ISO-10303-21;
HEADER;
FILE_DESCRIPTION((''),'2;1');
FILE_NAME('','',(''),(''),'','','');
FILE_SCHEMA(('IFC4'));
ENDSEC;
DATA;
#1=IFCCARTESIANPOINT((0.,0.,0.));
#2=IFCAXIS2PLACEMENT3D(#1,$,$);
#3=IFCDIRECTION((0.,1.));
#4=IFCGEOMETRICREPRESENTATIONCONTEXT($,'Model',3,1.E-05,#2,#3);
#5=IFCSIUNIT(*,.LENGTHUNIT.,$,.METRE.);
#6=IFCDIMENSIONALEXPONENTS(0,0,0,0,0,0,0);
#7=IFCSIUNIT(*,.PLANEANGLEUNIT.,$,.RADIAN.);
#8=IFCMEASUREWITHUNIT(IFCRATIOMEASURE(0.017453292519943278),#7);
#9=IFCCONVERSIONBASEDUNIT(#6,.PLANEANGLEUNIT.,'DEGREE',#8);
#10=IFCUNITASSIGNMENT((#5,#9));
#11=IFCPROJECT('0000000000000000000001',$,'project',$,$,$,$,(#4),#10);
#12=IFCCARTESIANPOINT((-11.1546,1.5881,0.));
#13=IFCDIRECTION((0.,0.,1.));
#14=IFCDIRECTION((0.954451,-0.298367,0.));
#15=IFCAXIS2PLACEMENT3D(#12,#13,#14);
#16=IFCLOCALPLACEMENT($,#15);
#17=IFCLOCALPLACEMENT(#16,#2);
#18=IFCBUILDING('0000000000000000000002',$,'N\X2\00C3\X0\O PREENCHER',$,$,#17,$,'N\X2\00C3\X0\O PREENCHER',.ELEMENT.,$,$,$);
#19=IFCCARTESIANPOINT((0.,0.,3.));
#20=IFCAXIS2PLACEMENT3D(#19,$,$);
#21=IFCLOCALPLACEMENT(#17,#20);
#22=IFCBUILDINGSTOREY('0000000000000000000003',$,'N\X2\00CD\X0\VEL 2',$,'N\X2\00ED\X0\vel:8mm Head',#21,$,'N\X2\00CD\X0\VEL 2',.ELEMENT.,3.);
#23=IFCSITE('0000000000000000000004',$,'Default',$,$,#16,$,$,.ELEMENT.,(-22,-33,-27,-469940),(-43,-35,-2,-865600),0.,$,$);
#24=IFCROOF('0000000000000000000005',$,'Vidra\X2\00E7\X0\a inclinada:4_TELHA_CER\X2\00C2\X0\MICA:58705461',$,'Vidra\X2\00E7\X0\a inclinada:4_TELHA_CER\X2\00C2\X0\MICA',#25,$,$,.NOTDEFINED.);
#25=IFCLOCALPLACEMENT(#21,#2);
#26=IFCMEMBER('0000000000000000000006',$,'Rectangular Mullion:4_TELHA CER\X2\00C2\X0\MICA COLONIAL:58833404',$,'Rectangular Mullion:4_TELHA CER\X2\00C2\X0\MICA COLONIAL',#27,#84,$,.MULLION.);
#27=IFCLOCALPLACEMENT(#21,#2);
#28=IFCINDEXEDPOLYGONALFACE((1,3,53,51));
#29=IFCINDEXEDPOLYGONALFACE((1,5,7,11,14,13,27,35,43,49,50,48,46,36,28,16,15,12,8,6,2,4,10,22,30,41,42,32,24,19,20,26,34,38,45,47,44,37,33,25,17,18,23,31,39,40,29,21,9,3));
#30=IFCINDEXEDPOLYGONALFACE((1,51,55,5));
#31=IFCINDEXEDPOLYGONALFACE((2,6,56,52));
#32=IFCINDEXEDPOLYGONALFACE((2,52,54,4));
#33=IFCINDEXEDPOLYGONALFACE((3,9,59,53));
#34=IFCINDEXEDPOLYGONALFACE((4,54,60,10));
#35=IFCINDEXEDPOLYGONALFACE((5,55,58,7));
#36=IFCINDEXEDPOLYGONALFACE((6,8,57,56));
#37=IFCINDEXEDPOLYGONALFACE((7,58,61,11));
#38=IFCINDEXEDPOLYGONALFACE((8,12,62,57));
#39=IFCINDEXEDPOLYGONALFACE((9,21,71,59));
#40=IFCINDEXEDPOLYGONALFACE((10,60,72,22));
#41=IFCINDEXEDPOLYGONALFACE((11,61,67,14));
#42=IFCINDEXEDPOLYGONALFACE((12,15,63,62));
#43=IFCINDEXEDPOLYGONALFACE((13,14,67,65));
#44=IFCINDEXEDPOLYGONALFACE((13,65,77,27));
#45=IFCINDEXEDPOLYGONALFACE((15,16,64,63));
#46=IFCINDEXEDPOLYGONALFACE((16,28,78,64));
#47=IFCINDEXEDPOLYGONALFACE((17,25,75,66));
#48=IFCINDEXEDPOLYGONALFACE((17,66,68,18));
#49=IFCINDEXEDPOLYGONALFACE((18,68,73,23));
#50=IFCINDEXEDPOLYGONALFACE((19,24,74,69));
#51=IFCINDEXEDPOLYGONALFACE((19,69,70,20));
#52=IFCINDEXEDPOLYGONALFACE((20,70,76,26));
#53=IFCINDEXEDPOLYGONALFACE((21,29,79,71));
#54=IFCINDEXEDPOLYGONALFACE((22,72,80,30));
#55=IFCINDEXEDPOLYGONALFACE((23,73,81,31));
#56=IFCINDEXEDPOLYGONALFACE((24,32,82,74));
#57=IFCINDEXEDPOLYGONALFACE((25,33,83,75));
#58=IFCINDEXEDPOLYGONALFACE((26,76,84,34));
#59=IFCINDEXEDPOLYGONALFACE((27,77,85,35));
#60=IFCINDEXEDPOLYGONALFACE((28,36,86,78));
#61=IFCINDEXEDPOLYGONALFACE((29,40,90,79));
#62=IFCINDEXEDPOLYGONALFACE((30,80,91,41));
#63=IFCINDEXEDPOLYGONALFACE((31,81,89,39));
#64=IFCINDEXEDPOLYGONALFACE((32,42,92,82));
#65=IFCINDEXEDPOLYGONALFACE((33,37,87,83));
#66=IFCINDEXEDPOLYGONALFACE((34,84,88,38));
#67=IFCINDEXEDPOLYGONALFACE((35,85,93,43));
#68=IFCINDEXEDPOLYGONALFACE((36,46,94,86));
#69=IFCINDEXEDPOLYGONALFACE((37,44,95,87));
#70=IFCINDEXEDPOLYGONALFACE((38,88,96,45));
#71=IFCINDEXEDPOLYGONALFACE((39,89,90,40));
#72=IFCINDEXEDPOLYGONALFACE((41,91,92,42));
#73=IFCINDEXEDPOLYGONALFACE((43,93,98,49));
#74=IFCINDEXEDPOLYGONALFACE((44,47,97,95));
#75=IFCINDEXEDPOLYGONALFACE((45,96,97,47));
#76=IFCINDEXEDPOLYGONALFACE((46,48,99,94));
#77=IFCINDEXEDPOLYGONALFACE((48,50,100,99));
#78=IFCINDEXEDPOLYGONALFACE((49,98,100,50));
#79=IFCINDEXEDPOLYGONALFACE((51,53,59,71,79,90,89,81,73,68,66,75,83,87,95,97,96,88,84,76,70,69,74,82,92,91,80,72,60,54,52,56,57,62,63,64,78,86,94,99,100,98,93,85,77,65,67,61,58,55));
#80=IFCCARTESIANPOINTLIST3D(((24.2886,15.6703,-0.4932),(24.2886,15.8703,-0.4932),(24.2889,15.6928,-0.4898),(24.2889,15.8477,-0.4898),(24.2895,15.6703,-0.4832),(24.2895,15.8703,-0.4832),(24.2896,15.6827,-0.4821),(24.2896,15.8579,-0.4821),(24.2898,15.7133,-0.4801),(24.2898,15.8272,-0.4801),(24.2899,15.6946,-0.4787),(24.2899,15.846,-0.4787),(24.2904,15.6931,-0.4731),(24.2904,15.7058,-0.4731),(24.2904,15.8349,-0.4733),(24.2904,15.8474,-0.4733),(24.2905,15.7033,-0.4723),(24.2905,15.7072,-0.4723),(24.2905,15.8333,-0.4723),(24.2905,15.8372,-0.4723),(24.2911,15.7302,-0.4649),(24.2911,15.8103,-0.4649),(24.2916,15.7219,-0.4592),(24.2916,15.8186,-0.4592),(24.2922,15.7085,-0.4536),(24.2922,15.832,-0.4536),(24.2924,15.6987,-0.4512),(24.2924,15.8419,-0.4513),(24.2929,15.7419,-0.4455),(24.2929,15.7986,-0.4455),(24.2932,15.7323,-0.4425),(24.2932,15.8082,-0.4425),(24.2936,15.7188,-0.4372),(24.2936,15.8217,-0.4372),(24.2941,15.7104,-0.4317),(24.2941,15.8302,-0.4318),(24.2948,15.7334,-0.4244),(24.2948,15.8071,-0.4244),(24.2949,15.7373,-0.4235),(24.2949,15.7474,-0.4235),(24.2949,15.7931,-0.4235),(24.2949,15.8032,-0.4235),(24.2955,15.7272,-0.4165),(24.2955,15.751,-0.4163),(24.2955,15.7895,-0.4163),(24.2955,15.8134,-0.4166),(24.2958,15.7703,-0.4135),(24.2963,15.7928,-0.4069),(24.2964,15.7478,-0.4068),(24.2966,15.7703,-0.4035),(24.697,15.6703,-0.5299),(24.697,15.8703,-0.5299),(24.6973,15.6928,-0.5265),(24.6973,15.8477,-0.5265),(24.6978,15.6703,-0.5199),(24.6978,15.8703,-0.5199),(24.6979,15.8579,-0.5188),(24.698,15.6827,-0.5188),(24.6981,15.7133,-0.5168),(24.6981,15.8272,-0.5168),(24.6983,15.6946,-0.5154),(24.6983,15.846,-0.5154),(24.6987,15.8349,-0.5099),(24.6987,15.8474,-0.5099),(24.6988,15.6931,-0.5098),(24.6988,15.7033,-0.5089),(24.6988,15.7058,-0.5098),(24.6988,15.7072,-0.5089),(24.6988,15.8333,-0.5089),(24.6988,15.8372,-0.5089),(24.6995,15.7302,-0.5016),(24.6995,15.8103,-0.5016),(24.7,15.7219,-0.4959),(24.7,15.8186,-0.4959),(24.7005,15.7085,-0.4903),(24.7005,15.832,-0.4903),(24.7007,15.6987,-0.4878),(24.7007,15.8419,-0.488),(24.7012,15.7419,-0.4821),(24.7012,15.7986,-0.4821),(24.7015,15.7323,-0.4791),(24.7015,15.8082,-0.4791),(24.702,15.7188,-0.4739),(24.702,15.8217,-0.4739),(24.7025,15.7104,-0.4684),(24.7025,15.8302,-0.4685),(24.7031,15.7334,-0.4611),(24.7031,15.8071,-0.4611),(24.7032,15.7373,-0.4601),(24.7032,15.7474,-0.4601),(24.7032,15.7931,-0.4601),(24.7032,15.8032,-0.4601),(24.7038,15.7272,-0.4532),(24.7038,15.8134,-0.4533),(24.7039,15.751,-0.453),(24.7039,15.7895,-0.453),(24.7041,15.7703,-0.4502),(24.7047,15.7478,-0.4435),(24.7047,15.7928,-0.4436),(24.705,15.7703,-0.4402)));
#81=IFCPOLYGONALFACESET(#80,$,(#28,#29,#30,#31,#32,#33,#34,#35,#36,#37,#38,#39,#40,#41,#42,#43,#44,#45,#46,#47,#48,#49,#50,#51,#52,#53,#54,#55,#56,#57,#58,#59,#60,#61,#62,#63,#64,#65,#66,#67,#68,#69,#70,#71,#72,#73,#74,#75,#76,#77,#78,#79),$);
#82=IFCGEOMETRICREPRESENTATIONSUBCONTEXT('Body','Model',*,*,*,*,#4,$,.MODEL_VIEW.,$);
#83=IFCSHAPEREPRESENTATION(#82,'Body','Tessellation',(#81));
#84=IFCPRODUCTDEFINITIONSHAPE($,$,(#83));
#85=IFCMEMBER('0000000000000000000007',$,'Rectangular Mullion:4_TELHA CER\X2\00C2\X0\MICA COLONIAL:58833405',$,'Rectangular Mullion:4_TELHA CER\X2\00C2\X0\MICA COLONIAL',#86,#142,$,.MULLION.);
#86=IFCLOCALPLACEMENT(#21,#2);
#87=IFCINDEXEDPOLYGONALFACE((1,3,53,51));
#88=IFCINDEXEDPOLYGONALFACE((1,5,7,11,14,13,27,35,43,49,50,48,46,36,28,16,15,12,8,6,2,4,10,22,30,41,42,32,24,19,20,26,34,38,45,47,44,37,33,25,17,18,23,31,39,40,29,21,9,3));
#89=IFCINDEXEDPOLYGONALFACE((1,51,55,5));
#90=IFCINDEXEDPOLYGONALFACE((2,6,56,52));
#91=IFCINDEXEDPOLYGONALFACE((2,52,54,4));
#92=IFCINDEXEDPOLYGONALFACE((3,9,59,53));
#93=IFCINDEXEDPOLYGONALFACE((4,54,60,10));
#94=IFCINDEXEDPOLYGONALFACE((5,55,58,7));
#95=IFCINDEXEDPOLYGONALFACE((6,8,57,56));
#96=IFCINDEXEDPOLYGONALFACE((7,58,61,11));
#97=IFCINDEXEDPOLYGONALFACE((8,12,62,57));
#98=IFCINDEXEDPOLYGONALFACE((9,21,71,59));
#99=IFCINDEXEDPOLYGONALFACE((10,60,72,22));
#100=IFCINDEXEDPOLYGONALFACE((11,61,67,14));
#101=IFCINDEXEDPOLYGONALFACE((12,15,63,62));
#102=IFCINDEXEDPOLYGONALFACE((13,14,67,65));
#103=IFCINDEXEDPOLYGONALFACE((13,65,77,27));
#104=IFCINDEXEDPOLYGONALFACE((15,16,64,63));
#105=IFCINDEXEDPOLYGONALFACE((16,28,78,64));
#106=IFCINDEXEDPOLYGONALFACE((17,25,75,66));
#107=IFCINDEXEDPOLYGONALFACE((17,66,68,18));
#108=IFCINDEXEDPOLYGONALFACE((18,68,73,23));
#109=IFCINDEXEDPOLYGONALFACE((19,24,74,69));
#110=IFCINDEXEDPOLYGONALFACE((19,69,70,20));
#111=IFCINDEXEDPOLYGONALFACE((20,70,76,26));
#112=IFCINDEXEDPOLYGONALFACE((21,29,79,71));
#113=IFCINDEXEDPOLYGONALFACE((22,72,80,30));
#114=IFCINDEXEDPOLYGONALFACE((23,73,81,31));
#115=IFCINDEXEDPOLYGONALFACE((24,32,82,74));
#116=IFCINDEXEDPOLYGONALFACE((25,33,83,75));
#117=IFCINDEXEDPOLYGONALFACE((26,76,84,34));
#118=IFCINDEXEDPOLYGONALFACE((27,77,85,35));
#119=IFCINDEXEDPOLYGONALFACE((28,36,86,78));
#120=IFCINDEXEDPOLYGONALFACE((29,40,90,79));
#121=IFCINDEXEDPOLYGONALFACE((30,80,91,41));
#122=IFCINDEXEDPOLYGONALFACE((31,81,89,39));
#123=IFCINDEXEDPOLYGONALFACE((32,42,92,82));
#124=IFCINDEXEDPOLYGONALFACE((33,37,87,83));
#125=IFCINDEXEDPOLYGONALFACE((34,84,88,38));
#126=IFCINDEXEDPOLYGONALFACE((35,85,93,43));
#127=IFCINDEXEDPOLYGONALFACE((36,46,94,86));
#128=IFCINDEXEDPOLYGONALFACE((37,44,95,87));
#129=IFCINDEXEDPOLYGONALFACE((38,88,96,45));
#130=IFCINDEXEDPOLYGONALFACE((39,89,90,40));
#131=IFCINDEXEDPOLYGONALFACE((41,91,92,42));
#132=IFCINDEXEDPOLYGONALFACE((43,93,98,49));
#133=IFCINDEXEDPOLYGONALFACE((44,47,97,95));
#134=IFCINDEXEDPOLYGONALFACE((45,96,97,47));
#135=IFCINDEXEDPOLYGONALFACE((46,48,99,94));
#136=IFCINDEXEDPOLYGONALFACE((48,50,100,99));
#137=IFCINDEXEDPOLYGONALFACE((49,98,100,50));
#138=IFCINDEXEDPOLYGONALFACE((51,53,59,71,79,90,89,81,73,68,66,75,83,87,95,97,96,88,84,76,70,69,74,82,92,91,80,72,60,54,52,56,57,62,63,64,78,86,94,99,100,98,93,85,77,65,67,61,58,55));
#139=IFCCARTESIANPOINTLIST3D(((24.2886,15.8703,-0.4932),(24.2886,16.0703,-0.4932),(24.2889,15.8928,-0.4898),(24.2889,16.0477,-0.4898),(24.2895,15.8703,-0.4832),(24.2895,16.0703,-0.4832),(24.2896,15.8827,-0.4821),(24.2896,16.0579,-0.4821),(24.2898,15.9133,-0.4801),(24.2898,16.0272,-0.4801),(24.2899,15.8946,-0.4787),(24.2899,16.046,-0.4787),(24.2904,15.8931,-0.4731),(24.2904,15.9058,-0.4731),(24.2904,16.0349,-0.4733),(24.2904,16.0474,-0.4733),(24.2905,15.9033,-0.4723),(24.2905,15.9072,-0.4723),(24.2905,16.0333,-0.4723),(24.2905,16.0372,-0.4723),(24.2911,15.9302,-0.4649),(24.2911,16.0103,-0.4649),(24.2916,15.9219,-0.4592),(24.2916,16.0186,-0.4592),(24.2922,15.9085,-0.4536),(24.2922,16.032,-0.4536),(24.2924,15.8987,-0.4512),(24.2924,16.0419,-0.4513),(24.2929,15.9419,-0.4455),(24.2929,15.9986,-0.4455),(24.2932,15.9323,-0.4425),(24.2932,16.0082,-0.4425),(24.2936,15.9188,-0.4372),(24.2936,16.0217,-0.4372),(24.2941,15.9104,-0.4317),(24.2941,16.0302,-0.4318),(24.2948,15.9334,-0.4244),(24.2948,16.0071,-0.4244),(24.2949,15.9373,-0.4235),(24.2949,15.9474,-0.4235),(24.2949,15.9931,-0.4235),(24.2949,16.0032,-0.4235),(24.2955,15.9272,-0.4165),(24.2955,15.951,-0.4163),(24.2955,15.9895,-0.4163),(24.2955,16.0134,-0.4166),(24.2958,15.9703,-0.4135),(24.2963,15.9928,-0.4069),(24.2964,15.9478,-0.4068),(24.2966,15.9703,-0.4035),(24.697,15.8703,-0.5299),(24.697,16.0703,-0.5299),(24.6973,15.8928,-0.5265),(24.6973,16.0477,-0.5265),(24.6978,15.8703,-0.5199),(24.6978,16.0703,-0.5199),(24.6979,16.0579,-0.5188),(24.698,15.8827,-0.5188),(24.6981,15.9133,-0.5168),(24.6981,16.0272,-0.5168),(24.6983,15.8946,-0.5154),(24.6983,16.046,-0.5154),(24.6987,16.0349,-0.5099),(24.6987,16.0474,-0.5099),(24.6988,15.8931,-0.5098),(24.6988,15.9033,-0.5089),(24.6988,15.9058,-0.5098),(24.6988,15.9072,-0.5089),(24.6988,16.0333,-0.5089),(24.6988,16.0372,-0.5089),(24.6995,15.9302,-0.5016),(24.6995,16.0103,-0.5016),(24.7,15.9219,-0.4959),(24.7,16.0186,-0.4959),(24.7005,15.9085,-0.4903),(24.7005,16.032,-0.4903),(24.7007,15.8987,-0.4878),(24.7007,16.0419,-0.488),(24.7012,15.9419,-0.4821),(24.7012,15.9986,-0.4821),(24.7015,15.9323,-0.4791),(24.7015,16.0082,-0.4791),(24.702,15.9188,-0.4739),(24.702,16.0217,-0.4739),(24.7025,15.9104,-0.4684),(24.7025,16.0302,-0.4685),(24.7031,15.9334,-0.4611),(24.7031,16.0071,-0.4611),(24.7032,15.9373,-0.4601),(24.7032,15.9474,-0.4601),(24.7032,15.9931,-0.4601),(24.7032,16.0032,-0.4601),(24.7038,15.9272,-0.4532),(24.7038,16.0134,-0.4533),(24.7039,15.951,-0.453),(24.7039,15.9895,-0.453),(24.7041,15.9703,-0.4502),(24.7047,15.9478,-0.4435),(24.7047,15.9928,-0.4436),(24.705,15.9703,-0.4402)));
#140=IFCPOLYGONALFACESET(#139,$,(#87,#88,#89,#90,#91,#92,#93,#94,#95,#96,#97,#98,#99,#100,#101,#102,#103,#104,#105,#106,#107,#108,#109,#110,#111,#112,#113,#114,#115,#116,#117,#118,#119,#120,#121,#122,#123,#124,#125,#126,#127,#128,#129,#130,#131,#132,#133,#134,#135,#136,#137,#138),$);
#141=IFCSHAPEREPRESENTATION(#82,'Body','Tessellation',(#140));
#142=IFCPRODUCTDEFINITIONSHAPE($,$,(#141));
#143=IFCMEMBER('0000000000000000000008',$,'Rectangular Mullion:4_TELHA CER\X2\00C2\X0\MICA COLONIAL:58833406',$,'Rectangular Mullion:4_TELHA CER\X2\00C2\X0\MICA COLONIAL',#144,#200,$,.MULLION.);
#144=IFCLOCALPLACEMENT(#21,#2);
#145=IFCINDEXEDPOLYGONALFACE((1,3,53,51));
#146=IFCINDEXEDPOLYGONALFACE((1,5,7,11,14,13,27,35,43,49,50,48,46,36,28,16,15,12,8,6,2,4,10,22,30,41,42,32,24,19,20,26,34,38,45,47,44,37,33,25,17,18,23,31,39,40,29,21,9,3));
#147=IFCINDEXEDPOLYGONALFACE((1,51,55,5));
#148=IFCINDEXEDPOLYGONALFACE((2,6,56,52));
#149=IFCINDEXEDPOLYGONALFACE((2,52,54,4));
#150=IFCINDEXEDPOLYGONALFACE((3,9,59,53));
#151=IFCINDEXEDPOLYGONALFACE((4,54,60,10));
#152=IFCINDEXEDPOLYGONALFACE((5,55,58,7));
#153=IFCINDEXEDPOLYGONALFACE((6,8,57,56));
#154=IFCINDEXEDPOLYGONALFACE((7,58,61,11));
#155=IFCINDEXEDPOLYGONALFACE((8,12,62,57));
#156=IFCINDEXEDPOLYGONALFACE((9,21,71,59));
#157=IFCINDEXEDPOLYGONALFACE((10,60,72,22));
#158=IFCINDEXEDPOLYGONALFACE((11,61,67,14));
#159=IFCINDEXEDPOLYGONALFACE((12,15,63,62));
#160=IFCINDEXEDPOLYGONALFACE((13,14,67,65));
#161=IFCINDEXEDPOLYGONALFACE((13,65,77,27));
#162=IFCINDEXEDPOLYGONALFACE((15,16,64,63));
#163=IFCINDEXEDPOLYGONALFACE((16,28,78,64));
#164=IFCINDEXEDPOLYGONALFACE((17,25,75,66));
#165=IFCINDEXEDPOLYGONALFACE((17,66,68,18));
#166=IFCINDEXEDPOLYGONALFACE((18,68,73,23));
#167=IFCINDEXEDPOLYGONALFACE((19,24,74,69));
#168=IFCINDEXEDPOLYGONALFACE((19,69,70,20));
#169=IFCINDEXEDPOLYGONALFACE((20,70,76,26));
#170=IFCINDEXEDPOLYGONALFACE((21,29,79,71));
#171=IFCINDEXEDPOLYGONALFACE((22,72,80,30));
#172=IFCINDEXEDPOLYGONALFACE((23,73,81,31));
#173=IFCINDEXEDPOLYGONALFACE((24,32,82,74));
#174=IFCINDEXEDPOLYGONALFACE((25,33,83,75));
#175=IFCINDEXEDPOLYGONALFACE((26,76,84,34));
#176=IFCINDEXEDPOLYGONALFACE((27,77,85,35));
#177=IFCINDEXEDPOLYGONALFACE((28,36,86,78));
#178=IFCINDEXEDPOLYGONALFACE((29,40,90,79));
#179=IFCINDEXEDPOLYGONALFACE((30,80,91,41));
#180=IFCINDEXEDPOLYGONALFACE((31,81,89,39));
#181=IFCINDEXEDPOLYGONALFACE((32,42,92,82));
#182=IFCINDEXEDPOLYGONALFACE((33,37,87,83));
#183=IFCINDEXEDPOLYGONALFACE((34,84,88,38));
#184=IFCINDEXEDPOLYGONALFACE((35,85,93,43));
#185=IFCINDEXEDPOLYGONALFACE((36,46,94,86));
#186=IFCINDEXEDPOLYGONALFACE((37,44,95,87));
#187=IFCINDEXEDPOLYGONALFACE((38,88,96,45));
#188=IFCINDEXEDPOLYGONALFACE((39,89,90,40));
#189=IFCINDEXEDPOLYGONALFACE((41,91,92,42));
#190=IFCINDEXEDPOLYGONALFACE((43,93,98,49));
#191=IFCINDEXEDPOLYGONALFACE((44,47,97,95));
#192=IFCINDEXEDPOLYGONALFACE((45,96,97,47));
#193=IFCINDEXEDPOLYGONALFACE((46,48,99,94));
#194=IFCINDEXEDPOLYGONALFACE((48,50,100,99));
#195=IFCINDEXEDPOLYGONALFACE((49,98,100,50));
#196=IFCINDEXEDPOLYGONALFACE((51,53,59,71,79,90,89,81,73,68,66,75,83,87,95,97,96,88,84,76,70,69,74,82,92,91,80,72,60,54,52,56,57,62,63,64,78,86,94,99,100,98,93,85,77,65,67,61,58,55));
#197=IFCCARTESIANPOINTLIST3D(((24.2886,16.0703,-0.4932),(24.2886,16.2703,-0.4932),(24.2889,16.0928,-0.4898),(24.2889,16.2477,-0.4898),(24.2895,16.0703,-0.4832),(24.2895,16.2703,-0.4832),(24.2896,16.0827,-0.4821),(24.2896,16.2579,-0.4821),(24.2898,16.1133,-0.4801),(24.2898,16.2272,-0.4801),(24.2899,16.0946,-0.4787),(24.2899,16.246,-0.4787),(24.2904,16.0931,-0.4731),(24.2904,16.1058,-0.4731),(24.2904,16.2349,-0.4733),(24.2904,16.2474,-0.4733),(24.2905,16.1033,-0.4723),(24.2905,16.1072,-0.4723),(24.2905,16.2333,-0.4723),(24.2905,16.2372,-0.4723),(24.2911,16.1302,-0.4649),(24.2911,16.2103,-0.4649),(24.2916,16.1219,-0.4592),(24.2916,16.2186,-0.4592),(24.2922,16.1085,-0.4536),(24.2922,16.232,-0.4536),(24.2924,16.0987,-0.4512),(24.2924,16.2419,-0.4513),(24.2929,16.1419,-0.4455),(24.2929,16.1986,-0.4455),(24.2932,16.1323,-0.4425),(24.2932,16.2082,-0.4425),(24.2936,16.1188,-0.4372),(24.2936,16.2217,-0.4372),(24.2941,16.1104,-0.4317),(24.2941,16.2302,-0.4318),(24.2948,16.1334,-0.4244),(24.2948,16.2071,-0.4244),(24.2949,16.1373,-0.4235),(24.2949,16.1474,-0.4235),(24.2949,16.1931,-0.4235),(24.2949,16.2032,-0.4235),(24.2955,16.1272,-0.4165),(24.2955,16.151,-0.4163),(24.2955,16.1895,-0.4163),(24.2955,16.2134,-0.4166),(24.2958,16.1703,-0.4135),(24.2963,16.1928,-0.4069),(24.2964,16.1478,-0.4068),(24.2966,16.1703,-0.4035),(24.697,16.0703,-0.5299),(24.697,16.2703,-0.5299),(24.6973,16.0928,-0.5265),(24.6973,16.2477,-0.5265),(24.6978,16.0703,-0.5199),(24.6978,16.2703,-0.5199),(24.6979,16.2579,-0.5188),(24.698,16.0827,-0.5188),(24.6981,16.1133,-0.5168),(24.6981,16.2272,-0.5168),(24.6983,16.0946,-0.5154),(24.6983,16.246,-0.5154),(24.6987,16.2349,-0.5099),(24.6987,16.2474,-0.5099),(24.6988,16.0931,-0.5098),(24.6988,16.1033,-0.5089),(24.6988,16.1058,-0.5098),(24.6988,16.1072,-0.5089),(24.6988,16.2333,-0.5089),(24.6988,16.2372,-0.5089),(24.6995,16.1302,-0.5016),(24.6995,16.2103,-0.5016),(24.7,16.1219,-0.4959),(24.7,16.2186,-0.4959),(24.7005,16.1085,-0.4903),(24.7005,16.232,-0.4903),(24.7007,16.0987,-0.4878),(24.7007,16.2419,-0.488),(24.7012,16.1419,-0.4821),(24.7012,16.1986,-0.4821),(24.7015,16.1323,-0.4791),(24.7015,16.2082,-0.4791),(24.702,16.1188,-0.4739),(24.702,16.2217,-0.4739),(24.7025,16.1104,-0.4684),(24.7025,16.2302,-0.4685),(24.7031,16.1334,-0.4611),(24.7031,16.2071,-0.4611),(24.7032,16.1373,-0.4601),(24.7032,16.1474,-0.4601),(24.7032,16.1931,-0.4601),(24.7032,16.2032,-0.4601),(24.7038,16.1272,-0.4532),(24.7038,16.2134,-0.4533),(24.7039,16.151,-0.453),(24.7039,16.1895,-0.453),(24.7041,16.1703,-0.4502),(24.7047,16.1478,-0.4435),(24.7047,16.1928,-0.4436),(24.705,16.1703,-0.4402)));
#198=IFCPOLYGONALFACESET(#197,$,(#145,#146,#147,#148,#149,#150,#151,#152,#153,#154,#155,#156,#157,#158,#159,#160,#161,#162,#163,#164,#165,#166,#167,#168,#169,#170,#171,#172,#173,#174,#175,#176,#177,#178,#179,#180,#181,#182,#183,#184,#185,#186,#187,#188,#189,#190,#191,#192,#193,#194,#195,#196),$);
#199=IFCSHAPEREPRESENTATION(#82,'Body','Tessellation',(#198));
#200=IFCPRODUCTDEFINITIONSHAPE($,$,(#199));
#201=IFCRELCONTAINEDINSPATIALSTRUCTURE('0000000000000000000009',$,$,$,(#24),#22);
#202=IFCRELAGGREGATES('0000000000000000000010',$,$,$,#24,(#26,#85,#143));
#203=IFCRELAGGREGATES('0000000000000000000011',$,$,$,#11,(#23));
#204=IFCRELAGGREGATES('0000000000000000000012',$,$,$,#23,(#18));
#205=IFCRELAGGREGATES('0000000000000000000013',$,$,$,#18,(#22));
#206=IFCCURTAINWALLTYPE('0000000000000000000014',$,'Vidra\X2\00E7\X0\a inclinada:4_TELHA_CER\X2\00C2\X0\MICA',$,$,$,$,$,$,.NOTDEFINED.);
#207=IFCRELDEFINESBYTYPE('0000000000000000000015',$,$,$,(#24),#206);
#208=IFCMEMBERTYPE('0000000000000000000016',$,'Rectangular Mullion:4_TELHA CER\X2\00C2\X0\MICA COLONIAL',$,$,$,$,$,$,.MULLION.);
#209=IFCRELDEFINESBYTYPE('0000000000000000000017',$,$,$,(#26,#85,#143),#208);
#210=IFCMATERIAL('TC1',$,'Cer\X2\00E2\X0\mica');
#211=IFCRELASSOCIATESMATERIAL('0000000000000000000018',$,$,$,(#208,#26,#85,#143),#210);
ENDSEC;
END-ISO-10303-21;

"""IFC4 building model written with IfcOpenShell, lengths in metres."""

from ifc_helpers import new_model, entity, si_unit, converted_unit, direction, frame, origin, place, context, subcontext, project, spatial, line, arc, indexed_curve, outline, extrude, source, transform, mapped, material, type_object, type_shapes, element, aggregate, save


model = new_model("IFC4")

# Units and contexts
model_context = context("Model", 3, precision=1e-05, world=origin(), true_north=direction((0.0, 1.0)))
body_context = subcontext(model_context, "Body", "Model", "MODEL_VIEW")
ifc_project = project(units=[si_unit("LENGTHUNIT", "METRE"), converted_unit("PLANEANGLEUNIT", "DEGREE", entity("IfcRatioMeasure", 0.017453292519943278), si_unit("PLANEANGLEUNIT", "RADIAN"), dimensions=[0, 0, 0, 0, 0, 0, 0])], contexts=[model_context])

# Site, building, storey
site_placement = place(None, frame((-11.1546, 1.5881, 0.0), z_axis=(0.0, 0.0, 1.0), x_axis=(0.954451, -0.298367, 0.0)))
site = spatial("IfcSite", under=ifc_project, at=site_placement, Name="Default", CompositionType="ELEMENT", RefLatitude=(-22, -33, -27, -469940), RefLongitude=(-43, -35, -2, -865600), RefElevation=0.0)
building_placement = place(site_placement, origin())
building = spatial("IfcBuilding", under=site, at=building_placement, Name="NÃO PREENCHER", LongName="NÃO PREENCHER", CompositionType="ELEMENT")
storey_placement = place(building_placement, frame((0.0, 0.0, 3.0)))
storey = spatial("IfcBuildingStorey", under=building, at=storey_placement, Name="NÍVEL 2", ObjectType="Nível:8mm Head", LongName="NÍVEL 2", CompositionType="ELEMENT", Elevation=3.0)

# Roof, members
curtain_wall_type = type_object("IfcCurtainWallType", Name="Vidraça inclinada:4_TELHA_CERÂMICA", PredefinedType="NOTDEFINED")
roof_placement = place(storey_placement, frame((0.0, 0.0, -3.0)))
roof = element("IfcRoof", 1, at=roof_placement, inside=storey, type_object=curtain_wall_type, Name="Vidraça inclinada:4_TELHA_CERÂMICA:58705461", ObjectType="Vidraça inclinada:4_TELHA_CERÂMICA", PredefinedType="NOTDEFINED")
ifc_material_1 = material(Name="TC1", Category="Cerâmica")
member_type_1 = type_object("IfcMemberType", Name="Rectangular Mullion:4_TELHA CERÂMICA COLONIAL", PredefinedType="MULLION", material=ifc_material_1)
shared_shape_1 = source(origin(), body_context, "Body", "SweptSolid", [
    extrude(outline(indexed_curve([(-0.029, -0.1), (-0.019, -0.1), (-0.0164, -0.0815), (-0.0089, -0.0645), (-0.0089, -0.0771), (0.061, 0.0), (-0.009, 0.0771), (-0.009, 0.0646), (-0.0165, 0.0816), (-0.019, 0.1), (-0.029, 0.1), (-0.0089, 0.0479), (0.041, 0.0229), (0.041, 0.0329), (0.0131, 0.0425), (-0.008, 0.0631), (-0.008, 0.067), (0.051, 0.0), (-0.008, -0.067), (-0.008, -0.0631), (0.0131, -0.0425), (0.041, -0.0329), (0.041, -0.0229), (-0.0089, -0.0479)], segments=[line(1, 2), arc(2, 3, 4), line(4, 5), arc(5, 6, 7), line(7, 8), arc(8, 9, 10), line(10, 11), arc(11, 12, 13), line(13, 14), arc(14, 15, 16), line(16, 17), arc(17, 18, 19), line(19, 20), arc(20, 21, 22), line(22, 23), arc(23, 24, 1)], self_intersect=False)), frame((0.0, -0.029, -0.41), z_axis=(0.0, 0.0, 1.0), x_axis=(0.0, -1.0, 0.0)), (0.0, 0.0, 1.0), 0.41),
])
type_shapes(member_type_1, [shared_shape_1])
member_1_placement = place(roof_placement, frame((24.2886, 15.7703, 2.5068), z_axis=(-0.99599, 0.0, 0.089469), x_axis=(0.0, 1.0, 0.0)))
member_1 = element("IfcMember", 2, at=member_1_placement, type_object=member_type_1, material=ifc_material_1, Name="Rectangular Mullion:4_TELHA CERÂMICA COLONIAL:58833404", ObjectType="Rectangular Mullion:4_TELHA CERÂMICA COLONIAL", PredefinedType="MULLION", context=body_context, shape_type="MappedRepresentation", body=[
    mapped(shared_shape_1, transform((0.0, 0.0, 0.0), scale=1.0)),
])
member_2_placement = place(roof_placement, frame((24.2886, 15.9703, 2.5068), z_axis=(-0.99599, 0.0, 0.089469), x_axis=(0.0, 1.0, 0.0)))
member_2 = element("IfcMember", 3, at=member_2_placement, type_object=member_type_1, material=ifc_material_1, Name="Rectangular Mullion:4_TELHA CERÂMICA COLONIAL:58833405", ObjectType="Rectangular Mullion:4_TELHA CERÂMICA COLONIAL", PredefinedType="MULLION", context=body_context, shape_type="MappedRepresentation", body=[
    mapped(shared_shape_1, transform((0.0, 0.0, 0.0), scale=1.0)),
])
member_3_placement = place(roof_placement, frame((24.2886, 16.1703, 2.5068), z_axis=(-0.99599, 0.0, 0.089469), x_axis=(0.0, 1.0, 0.0)))
member_3 = element("IfcMember", 4, at=member_3_placement, type_object=member_type_1, material=ifc_material_1, Name="Rectangular Mullion:4_TELHA CERÂMICA COLONIAL:58833406", ObjectType="Rectangular Mullion:4_TELHA CERÂMICA COLONIAL", PredefinedType="MULLION", context=body_context, shape_type="MappedRepresentation", body=[
    mapped(shared_shape_1, transform((0.0, 0.0, 0.0), scale=1.0)),
])
aggregate(roof, [member_1, member_2, member_3])

save(model, "model.ifc")
